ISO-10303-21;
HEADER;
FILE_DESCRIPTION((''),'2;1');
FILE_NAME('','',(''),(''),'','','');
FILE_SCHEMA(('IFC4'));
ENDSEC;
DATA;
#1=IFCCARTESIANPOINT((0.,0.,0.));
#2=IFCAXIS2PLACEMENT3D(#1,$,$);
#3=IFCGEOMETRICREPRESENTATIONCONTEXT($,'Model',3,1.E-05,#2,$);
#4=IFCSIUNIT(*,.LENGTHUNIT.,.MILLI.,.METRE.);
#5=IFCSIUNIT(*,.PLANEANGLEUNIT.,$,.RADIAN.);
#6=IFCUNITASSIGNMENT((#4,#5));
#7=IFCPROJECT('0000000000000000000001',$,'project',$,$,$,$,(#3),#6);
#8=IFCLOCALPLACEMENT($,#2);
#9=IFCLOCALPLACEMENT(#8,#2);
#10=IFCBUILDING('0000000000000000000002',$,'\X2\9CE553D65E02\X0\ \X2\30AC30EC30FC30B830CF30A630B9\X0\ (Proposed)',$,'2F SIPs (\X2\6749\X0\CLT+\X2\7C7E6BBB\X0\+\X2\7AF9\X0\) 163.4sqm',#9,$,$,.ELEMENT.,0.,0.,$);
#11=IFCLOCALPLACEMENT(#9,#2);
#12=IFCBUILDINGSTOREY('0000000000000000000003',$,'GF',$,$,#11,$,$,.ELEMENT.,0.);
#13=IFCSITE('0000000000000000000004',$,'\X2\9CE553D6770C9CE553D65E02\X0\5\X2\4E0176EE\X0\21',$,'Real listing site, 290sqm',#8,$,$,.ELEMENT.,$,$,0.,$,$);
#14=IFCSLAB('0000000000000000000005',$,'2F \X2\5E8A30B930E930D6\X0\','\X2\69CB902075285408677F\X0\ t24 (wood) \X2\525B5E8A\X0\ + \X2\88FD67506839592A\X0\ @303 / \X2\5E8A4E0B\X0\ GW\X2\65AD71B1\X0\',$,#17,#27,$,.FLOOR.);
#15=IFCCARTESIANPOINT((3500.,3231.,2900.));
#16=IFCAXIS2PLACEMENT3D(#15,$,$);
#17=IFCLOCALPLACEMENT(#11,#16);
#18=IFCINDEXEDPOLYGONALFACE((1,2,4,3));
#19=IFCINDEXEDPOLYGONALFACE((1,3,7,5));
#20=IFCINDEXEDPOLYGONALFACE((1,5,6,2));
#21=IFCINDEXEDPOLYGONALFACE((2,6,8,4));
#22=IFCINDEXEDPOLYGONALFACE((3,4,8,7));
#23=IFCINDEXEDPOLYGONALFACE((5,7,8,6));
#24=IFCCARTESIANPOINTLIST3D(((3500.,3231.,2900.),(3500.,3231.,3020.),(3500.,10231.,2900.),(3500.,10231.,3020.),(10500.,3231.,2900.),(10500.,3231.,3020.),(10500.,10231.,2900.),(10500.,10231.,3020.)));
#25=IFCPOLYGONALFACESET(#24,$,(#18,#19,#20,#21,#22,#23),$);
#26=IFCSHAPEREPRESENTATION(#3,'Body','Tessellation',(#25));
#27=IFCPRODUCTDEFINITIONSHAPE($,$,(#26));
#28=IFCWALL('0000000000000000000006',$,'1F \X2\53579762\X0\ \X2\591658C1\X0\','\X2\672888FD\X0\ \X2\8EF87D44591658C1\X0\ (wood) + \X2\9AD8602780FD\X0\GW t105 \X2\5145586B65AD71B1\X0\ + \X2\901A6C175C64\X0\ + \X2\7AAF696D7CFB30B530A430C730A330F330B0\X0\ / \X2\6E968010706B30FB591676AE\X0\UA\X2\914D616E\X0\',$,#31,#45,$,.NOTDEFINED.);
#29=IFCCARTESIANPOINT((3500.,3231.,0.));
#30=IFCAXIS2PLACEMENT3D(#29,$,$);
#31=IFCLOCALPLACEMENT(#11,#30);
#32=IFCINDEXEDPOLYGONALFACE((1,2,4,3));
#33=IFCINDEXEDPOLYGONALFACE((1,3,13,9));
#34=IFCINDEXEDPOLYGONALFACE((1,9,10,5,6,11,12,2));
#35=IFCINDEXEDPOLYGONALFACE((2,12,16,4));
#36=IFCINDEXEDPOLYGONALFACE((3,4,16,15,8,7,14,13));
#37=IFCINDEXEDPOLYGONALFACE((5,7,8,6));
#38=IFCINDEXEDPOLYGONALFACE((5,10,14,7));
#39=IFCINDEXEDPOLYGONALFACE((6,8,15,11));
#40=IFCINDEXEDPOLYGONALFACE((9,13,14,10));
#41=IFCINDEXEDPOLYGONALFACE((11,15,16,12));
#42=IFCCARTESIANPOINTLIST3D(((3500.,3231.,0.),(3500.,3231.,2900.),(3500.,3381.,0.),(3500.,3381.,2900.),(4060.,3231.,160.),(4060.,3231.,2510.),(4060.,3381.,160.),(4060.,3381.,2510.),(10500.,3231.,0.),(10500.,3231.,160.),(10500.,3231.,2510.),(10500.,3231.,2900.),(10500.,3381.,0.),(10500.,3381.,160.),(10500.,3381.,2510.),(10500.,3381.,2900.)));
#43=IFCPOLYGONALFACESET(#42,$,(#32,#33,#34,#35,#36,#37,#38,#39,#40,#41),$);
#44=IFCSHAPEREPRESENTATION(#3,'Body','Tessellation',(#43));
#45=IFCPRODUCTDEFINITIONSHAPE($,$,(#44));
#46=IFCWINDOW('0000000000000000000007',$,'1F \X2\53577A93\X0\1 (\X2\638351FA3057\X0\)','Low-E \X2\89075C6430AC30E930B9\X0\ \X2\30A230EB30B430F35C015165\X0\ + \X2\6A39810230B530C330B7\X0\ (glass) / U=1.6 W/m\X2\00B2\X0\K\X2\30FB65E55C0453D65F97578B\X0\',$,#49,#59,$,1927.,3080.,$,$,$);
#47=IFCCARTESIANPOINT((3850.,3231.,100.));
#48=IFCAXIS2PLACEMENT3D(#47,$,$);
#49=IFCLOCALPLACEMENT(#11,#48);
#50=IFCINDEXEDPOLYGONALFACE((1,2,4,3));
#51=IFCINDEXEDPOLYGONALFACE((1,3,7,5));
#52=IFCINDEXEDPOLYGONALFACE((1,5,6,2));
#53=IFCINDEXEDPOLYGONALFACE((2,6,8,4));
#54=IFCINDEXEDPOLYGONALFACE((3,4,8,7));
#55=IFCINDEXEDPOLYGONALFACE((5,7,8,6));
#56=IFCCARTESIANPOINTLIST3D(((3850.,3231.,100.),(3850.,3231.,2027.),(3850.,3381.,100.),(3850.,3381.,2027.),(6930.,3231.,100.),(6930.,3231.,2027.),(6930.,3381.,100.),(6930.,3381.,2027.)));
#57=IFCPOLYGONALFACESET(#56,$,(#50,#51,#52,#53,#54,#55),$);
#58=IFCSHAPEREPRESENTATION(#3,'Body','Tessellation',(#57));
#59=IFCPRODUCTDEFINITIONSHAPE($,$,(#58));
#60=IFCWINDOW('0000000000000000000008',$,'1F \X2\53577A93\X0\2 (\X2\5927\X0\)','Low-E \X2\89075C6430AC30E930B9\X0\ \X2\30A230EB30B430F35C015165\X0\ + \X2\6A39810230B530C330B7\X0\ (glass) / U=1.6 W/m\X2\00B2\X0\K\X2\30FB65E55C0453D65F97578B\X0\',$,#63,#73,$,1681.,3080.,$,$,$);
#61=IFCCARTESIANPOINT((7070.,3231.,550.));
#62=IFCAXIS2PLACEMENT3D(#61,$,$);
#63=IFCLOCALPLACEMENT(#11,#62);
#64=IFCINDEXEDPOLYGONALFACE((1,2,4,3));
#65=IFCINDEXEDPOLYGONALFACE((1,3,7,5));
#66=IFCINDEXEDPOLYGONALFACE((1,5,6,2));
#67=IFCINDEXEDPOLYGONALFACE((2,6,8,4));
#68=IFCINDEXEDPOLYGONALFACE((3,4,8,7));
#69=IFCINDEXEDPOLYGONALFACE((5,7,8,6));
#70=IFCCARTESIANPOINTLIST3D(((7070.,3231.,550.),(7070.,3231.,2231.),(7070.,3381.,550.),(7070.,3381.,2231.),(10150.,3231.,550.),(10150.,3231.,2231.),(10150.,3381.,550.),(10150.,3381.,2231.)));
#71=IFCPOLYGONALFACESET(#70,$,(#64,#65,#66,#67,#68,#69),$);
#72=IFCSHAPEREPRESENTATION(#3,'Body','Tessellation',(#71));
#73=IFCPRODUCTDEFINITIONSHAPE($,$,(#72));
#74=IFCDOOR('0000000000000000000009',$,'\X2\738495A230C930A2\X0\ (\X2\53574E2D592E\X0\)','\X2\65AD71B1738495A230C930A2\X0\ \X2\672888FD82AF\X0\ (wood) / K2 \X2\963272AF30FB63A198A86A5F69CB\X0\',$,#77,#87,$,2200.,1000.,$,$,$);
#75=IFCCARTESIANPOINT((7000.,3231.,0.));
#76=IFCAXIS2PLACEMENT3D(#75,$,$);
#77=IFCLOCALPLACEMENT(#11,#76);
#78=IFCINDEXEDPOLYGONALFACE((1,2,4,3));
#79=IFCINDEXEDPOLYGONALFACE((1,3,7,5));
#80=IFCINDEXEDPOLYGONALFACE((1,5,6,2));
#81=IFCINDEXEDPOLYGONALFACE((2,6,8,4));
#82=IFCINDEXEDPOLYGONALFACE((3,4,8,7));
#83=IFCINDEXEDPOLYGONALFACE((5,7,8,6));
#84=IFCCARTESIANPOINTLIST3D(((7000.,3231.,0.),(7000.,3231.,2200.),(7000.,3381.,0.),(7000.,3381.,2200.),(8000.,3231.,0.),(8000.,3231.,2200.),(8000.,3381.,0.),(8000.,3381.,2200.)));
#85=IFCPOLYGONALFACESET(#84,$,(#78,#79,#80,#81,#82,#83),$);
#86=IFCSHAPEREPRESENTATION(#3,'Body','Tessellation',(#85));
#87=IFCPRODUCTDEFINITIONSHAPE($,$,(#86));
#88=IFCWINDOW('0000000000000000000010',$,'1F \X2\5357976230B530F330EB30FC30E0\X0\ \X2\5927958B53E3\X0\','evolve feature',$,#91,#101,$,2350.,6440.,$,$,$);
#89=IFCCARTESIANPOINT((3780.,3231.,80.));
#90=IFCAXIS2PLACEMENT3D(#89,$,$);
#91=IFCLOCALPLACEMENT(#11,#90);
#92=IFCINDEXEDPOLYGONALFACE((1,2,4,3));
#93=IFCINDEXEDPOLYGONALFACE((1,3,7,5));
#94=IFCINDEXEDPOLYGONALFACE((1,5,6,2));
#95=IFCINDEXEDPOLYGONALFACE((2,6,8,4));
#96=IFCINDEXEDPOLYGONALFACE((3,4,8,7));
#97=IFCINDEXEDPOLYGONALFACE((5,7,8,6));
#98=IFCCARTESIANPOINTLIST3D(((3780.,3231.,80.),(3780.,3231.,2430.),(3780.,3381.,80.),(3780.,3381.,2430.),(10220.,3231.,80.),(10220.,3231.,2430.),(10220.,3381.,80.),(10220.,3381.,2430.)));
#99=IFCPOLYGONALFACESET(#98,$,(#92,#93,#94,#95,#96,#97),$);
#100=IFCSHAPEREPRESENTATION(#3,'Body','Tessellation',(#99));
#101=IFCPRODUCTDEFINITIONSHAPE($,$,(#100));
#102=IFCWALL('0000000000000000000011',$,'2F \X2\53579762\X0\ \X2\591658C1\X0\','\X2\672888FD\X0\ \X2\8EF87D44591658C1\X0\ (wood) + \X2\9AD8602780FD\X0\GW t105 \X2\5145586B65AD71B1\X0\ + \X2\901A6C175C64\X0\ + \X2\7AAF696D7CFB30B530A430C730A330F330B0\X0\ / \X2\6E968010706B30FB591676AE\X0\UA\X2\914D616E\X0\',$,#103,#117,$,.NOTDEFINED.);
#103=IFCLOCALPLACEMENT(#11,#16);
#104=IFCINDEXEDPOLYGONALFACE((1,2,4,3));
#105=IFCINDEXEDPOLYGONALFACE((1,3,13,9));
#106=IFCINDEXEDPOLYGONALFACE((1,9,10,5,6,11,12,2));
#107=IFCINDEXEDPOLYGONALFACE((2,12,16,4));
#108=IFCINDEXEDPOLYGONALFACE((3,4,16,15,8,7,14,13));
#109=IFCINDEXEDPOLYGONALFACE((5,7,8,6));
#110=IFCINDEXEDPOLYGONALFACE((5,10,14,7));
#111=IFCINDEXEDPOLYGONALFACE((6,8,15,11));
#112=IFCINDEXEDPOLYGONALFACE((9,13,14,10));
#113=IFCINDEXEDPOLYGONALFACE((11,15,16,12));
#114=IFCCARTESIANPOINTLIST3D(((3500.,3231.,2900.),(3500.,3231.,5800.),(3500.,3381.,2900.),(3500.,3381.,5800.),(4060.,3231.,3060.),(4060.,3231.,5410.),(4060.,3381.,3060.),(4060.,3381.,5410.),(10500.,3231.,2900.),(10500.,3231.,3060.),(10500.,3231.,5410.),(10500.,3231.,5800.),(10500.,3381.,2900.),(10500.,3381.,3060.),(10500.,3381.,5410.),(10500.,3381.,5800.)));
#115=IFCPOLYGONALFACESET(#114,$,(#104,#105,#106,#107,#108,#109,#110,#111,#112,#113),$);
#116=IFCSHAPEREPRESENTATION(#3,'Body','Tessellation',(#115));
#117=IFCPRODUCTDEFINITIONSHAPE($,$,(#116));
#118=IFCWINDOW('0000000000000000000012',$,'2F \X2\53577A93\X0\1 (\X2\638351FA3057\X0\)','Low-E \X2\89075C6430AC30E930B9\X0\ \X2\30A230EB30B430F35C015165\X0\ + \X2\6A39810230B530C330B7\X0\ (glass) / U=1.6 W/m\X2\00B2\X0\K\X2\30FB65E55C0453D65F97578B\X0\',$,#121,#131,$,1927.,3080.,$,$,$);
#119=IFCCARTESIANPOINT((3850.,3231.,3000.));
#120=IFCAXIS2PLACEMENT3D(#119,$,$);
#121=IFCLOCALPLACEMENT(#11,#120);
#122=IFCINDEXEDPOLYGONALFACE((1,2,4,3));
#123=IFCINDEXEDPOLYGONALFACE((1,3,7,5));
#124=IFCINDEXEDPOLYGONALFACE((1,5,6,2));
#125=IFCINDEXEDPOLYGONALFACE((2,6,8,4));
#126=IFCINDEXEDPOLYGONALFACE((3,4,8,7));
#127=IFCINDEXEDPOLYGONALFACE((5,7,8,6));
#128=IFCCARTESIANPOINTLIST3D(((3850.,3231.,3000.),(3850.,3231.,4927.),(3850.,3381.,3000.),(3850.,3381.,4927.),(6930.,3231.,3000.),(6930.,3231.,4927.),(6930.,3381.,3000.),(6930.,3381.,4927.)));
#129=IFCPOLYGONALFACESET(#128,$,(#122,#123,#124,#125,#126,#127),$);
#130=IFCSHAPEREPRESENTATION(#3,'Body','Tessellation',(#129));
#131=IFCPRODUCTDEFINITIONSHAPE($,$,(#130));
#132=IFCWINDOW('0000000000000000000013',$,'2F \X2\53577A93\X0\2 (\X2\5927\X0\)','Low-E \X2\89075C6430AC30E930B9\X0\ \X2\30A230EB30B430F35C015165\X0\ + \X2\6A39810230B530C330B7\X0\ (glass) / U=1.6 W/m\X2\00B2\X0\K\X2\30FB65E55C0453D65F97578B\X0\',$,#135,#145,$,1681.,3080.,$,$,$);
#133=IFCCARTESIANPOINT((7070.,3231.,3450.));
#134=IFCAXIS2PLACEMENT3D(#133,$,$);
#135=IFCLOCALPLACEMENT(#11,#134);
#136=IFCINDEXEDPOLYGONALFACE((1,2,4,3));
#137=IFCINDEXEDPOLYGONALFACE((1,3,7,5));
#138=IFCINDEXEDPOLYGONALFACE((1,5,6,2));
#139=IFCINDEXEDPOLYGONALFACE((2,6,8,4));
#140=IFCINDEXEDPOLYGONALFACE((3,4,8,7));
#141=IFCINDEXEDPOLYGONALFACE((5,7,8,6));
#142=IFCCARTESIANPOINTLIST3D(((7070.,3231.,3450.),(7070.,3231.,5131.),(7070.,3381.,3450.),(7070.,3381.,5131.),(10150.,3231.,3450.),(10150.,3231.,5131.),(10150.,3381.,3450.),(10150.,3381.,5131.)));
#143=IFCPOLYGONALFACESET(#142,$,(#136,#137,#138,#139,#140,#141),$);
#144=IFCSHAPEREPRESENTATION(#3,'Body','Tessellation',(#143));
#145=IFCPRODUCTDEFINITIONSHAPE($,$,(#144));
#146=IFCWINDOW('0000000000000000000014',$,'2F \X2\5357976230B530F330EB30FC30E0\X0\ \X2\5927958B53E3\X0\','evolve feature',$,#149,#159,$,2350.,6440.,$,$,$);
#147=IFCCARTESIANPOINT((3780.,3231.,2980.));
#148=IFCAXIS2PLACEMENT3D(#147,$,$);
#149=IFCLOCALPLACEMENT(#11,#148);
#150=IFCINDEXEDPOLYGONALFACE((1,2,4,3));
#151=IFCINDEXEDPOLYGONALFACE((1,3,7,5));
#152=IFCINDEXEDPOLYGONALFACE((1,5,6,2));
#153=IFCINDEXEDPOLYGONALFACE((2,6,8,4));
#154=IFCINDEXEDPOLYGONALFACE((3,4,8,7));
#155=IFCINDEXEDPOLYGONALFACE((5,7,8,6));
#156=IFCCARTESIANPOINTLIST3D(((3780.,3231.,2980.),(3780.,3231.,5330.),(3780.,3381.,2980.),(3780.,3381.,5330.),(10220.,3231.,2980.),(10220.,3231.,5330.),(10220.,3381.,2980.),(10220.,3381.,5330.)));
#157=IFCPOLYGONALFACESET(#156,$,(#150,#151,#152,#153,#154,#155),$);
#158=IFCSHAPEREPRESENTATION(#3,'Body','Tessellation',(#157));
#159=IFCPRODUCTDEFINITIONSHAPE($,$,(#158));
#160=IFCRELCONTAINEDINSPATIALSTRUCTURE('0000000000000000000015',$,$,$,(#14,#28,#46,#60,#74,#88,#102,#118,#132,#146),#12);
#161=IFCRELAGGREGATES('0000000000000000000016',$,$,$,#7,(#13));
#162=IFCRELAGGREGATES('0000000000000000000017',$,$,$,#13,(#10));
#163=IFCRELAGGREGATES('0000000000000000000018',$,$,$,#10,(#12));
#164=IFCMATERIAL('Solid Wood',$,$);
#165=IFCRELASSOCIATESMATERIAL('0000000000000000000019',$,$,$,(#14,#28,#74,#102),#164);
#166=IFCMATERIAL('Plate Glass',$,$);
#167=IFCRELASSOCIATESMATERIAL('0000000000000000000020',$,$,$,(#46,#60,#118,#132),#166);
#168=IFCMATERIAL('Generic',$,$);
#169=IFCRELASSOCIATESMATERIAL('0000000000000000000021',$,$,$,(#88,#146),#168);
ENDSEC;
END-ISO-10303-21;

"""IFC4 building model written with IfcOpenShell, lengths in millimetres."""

from ifc_helpers import new_model, si_unit, frame, frame_2d, origin, place, context, project, spatial, rectangle, extrude, material, element, fill, save


model = new_model("IFC4")

# Units and contexts
model_context = context("Model", 3, precision=1e-05, world=origin())
ifc_project = project(units=[si_unit("LENGTHUNIT", "METRE", prefix="MILLI"), si_unit("PLANEANGLEUNIT", "RADIAN")], contexts=[model_context])

# Site, building, storey
site_placement = place(None, origin())
site = spatial("IfcSite", under=ifc_project, at=site_placement, Name="鳥取県鳥取市5丁目21", ObjectType="Real listing site, 290sqm", CompositionType="ELEMENT", RefElevation=0.0)
building_placement = place(site_placement, origin())
building = spatial("IfcBuilding", under=site, at=building_placement, Name="鳥取市 ガレージハウス (Proposed)", ObjectType="2F SIPs (杉CLT+籾殻+竹) 163.4sqm", CompositionType="ELEMENT", ElevationOfRefHeight=0.0, ElevationOfTerrain=0.0)
storey_placement = place(building_placement, origin())
storey = spatial("IfcBuildingStorey", under=building, at=storey_placement, Name="GF", CompositionType="ELEMENT", Elevation=0.0)

# Slab
ifc_material_1 = material(Name="Solid Wood")
slab_1_placement = place(storey_placement, frame((3500.0, 3231.0, 2900.0)))
element("IfcSlab", 1, at=slab_1_placement, inside=storey, material=ifc_material_1, Name="2F 床スラブ", Description="構造用合板 t24 (wood) 剛床 + 製材根太 @303 / 床下 GW断熱", PredefinedType="FLOOR", context=model_context, shape_type="SweptSolid", body=[
    extrude(rectangle(XDim=7000.0, YDim=7000.0, at=frame_2d((3500.0, 3500.0))), frame((3500.0, 3231.0, 2900.0)), (0.0, 0.0, 1.0), 120.0),
])
ifc_material_2 = material(Name="Generic")

# Wall, openings, windows, door
wall_1_placement = place(storey_placement, frame((3500.0, 3231.0, 0.0)))
wall_1 = element("IfcWall", 2, at=wall_1_placement, inside=storey, material=ifc_material_1, Name="1F 南面 外壁", Description="木製 軸組外壁 (wood) + 高性能GW t105 充填断熱 + 通気層 + 窯業系サイディング / 準耐火・外皮UA配慮", PredefinedType="NOTDEFINED", context=model_context, shape_type="SweptSolid", body=[
    extrude(rectangle(XDim=7000.0, YDim=150.0, at=frame_2d((3500.0, 75.0))), frame((3500.0, 3231.0, 0.0)), (0.0, 0.0, 1.0), 2900.0),
])
opening_1_placement = place(storey_placement, frame((3850.0, 3231.0, 100.0)))
opening_1 = element("IfcOpeningElement", 3, at=opening_1_placement, cuts=wall_1, PredefinedType="NOTDEFINED", context=model_context, shape_type="SweptSolid", body=[
    extrude(rectangle(XDim=3080.0, YDim=150.0, at=frame_2d((1540.0, 75.0))), frame((3850.0, 3231.0, 100.0)), (0.0, 0.0, 1.0), 1927.0),
])
opening_2_placement = place(storey_placement, frame((7070.0, 3231.0, 550.0)))
opening_2 = element("IfcOpeningElement", 4, at=opening_2_placement, cuts=wall_1, PredefinedType="NOTDEFINED", context=model_context, shape_type="SweptSolid", body=[
    extrude(rectangle(XDim=3080.0, YDim=150.0, at=frame_2d((1540.0, 75.0))), frame((7070.0, 3231.0, 550.0)), (0.0, 0.0, 1.0), 1681.0),
])
opening_3_placement = place(storey_placement, frame((7000.0, 3231.0, 0.0)))
opening_3 = element("IfcOpeningElement", 5, at=opening_3_placement, cuts=wall_1, PredefinedType="NOTDEFINED", context=model_context, shape_type="SweptSolid", body=[
    extrude(rectangle(XDim=1000.0, YDim=150.0, at=frame_2d((500.0, 75.0))), frame((7000.0, 3231.0, 0.0)), (0.0, 0.0, 1.0), 2200.0),
])
opening_4_placement = place(storey_placement, frame((3780.0, 3231.0, 80.0)))
opening_4 = element("IfcOpeningElement", 6, at=opening_4_placement, cuts=wall_1, PredefinedType="NOTDEFINED", context=model_context, shape_type="SweptSolid", body=[
    extrude(rectangle(XDim=6440.0, YDim=150.0, at=frame_2d((3220.0, 75.0))), frame((3780.0, 3231.0, 80.0)), (0.0, 0.0, 1.0), 2350.0),
])
ifc_material_3 = material(Name="Plate Glass")
window_1_placement = place(storey_placement, frame((3850.0, 3231.0, 100.0)))
window_1 = element("IfcWindow", 7, at=window_1_placement, inside=storey, material=ifc_material_3, Name="1F 南窓1 (掃出し)", Description="Low-E 複層ガラス アルゴン封入 + 樹脂サッシ (glass) / U=1.6 W/m²K・日射取得型", OverallHeight=1927.0, OverallWidth=3080.0, context=model_context, shape_type="SweptSolid", body=[
    extrude(rectangle(XDim=3080.0, YDim=150.0, at=frame_2d((1540.0, 75.0))), frame((3850.0, 3231.0, 100.0)), (0.0, 0.0, 1.0), 1927.0),
])
fill(opening_1, window_1)
window_2_placement = place(storey_placement, frame((7070.0, 3231.0, 550.0)))
window_2 = element("IfcWindow", 8, at=window_2_placement, inside=storey, material=ifc_material_3, Name="1F 南窓2 (大)", Description="Low-E 複層ガラス アルゴン封入 + 樹脂サッシ (glass) / U=1.6 W/m²K・日射取得型", OverallHeight=1681.0, OverallWidth=3080.0, context=model_context, shape_type="SweptSolid", body=[
    extrude(rectangle(XDim=3080.0, YDim=150.0, at=frame_2d((1540.0, 75.0))), frame((7070.0, 3231.0, 550.0)), (0.0, 0.0, 1.0), 1681.0),
])
fill(opening_2, window_2)
door_placement = place(storey_placement, frame((7000.0, 3231.0, 0.0)))
door = element("IfcDoor", 9, at=door_placement, inside=storey, material=ifc_material_1, Name="玄関ドア (南中央)", Description="断熱玄関ドア 木製芯 (wood) / K2 防犯・採風機構", OverallHeight=2200.0, OverallWidth=1000.0, context=model_context, shape_type="SweptSolid", body=[
    extrude(rectangle(XDim=1000.0, YDim=150.0, at=frame_2d((500.0, 75.0))), frame((7000.0, 3231.0, 0.0)), (0.0, 0.0, 1.0), 2200.0),
])
fill(opening_3, door)
window_3_placement = place(storey_placement, frame((3780.0, 3231.0, 80.0)))
window_3 = element("IfcWindow", 10, at=window_3_placement, inside=storey, material=ifc_material_2, Name="1F 南面サンルーム 大開口", Description="evolve feature", OverallHeight=2350.0, OverallWidth=6440.0, context=model_context, shape_type="SweptSolid", body=[
    extrude(rectangle(XDim=6440.0, YDim=150.0, at=frame_2d((3220.0, 75.0))), frame((3780.0, 3231.0, 80.0)), (0.0, 0.0, 1.0), 2350.0),
])
fill(opening_4, window_3)

# Wall, openings, windows
wall_2_placement = place(storey_placement, frame((3500.0, 3231.0, 2900.0)))
wall_2 = element("IfcWall", 11, at=wall_2_placement, inside=storey, material=ifc_material_1, Name="2F 南面 外壁", Description="木製 軸組外壁 (wood) + 高性能GW t105 充填断熱 + 通気層 + 窯業系サイディング / 準耐火・外皮UA配慮", PredefinedType="NOTDEFINED", context=model_context, shape_type="SweptSolid", body=[
    extrude(rectangle(XDim=7000.0, YDim=150.0, at=frame_2d((3500.0, 75.0))), frame((3500.0, 3231.0, 2900.0)), (0.0, 0.0, 1.0), 2900.0),
])
opening_5_placement = place(storey_placement, frame((3850.0, 3231.0, 3000.0)))
opening_5 = element("IfcOpeningElement", 12, at=opening_5_placement, cuts=wall_2, PredefinedType="NOTDEFINED", context=model_context, shape_type="SweptSolid", body=[
    extrude(rectangle(XDim=3080.0, YDim=150.0, at=frame_2d((1540.0, 75.0))), frame((3850.0, 3231.0, 3000.0)), (0.0, 0.0, 1.0), 1927.0),
])
opening_6_placement = place(storey_placement, frame((7070.0, 3231.0, 3450.0)))
opening_6 = element("IfcOpeningElement", 13, at=opening_6_placement, cuts=wall_2, PredefinedType="NOTDEFINED", context=model_context, shape_type="SweptSolid", body=[
    extrude(rectangle(XDim=3080.0, YDim=150.0, at=frame_2d((1540.0, 75.0))), frame((7070.0, 3231.0, 3450.0)), (0.0, 0.0, 1.0), 1681.0),
])
opening_7_placement = place(storey_placement, frame((3780.0, 3231.0, 2980.0)))
opening_7 = element("IfcOpeningElement", 14, at=opening_7_placement, cuts=wall_2, PredefinedType="NOTDEFINED", context=model_context, shape_type="SweptSolid", body=[
    extrude(rectangle(XDim=6440.0, YDim=150.0, at=frame_2d((3220.0, 75.0))), frame((3780.0, 3231.0, 2980.0)), (0.0, 0.0, 1.0), 2350.0),
])
window_4_placement = place(storey_placement, frame((3850.0, 3231.0, 3000.0)))
window_4 = element("IfcWindow", 15, at=window_4_placement, inside=storey, material=ifc_material_3, Name="2F 南窓1 (掃出し)", Description="Low-E 複層ガラス アルゴン封入 + 樹脂サッシ (glass) / U=1.6 W/m²K・日射取得型", OverallHeight=1927.0, OverallWidth=3080.0, context=model_context, shape_type="SweptSolid", body=[
    extrude(rectangle(XDim=3080.0, YDim=150.0, at=frame_2d((1540.0, 75.0))), frame((3850.0, 3231.0, 3000.0)), (0.0, 0.0, 1.0), 1927.0),
])
fill(opening_5, window_4)
window_5_placement = place(storey_placement, frame((7070.0, 3231.0, 3450.0)))
window_5 = element("IfcWindow", 16, at=window_5_placement, inside=storey, material=ifc_material_3, Name="2F 南窓2 (大)", Description="Low-E 複層ガラス アルゴン封入 + 樹脂サッシ (glass) / U=1.6 W/m²K・日射取得型", OverallHeight=1681.0, OverallWidth=3080.0, context=model_context, shape_type="SweptSolid", body=[
    extrude(rectangle(XDim=3080.0, YDim=150.0, at=frame_2d((1540.0, 75.0))), frame((7070.0, 3231.0, 3450.0)), (0.0, 0.0, 1.0), 1681.0),
])
fill(opening_6, window_5)
window_6_placement = place(storey_placement, frame((3780.0, 3231.0, 2980.0)))
window_6 = element("IfcWindow", 17, at=window_6_placement, inside=storey, material=ifc_material_2, Name="2F 南面サンルーム 大開口", Description="evolve feature", OverallHeight=2350.0, OverallWidth=6440.0, context=model_context, shape_type="SweptSolid", body=[
    extrude(rectangle(XDim=6440.0, YDim=150.0, at=frame_2d((3220.0, 75.0))), frame((3780.0, 3231.0, 2980.0)), (0.0, 0.0, 1.0), 2350.0),
])
fill(opening_7, window_6)

save(model, "model.ifc")
